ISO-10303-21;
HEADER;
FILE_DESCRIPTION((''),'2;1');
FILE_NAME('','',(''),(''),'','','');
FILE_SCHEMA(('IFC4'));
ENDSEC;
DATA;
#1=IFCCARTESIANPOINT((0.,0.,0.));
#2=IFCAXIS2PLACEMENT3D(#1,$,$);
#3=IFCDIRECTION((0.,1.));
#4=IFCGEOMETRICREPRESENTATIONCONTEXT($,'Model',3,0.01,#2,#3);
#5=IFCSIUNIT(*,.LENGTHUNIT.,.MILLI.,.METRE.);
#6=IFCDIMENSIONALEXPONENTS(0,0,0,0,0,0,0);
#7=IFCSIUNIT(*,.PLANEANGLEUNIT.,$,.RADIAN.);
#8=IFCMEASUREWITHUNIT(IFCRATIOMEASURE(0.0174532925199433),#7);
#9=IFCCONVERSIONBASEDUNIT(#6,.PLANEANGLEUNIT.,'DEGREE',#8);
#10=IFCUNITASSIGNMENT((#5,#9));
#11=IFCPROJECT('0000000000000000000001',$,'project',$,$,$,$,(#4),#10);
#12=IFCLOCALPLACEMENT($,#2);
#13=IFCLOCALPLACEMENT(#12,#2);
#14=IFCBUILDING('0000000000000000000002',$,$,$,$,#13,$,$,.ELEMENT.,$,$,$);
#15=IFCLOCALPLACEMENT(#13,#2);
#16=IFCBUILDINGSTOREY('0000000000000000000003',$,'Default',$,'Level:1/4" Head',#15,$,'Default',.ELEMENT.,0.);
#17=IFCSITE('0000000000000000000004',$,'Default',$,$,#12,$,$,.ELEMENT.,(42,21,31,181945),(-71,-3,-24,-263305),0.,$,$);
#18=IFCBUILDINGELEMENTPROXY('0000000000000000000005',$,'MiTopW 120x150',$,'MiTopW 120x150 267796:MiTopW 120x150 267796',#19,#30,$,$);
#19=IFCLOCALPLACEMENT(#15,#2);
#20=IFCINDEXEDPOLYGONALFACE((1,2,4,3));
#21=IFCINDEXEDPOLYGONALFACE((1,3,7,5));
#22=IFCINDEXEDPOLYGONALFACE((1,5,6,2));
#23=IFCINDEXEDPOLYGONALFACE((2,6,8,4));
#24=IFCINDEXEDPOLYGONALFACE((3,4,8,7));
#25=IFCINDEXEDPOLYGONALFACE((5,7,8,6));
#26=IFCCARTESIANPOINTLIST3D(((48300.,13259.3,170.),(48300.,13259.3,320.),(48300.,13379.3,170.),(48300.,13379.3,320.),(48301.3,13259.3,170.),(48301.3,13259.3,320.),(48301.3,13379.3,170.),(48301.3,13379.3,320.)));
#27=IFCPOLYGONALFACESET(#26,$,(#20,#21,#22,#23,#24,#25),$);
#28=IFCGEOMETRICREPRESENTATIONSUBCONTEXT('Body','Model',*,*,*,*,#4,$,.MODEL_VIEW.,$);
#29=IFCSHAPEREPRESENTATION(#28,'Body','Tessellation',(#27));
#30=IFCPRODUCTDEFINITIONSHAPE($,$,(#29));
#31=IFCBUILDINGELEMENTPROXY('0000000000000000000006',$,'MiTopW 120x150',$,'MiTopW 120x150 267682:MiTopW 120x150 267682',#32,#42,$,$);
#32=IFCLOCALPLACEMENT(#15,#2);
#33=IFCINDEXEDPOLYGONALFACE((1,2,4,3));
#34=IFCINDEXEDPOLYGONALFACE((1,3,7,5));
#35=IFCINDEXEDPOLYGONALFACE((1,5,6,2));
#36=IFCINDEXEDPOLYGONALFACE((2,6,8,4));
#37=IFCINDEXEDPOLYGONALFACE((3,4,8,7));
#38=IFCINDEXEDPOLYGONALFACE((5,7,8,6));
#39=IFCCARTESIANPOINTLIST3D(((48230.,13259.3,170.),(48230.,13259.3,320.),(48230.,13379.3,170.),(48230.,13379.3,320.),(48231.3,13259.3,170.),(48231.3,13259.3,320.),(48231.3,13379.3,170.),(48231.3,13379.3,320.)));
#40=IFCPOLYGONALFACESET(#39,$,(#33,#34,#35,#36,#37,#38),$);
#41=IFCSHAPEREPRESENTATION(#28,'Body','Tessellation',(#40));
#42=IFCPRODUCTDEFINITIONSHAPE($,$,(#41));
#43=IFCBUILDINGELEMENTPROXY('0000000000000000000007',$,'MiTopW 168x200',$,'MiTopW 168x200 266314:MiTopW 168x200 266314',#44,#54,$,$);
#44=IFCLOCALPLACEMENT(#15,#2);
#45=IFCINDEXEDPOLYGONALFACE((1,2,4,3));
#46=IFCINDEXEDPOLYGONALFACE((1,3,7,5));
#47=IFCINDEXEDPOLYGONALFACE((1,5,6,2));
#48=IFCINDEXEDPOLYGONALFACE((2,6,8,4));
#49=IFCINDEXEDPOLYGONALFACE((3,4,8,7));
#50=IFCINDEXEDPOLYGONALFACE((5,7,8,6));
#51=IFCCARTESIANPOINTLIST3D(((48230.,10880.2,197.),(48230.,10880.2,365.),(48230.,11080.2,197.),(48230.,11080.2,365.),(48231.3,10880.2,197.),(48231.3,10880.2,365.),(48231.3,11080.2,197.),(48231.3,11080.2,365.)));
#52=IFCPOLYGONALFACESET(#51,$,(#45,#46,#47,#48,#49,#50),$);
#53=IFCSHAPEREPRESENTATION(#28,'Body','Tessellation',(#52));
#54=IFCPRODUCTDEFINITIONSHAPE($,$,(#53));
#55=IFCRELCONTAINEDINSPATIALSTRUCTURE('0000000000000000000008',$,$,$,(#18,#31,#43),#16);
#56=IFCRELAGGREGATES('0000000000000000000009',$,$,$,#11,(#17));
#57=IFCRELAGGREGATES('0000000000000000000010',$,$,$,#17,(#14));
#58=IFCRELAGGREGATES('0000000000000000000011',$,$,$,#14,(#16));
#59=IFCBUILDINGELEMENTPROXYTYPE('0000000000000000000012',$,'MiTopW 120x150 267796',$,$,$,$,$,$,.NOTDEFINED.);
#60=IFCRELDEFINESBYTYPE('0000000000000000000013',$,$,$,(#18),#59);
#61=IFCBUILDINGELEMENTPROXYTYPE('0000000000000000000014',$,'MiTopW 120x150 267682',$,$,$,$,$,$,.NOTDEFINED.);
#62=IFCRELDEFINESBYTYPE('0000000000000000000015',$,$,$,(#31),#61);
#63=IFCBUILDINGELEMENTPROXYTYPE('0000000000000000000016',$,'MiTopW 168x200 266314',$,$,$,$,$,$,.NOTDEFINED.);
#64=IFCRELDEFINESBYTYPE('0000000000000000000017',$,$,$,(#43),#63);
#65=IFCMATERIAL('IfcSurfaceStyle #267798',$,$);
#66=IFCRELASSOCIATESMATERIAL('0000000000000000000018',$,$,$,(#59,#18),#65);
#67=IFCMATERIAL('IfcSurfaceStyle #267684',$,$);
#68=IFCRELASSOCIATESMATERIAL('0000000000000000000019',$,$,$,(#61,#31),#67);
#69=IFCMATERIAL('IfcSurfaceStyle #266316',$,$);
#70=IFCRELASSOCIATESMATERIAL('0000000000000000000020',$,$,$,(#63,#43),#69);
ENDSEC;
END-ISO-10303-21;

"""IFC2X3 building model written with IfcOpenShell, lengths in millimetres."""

from ifc_helpers import new_model, entity, si_unit, converted_unit, direction, frame, origin, origin_2d_with_axis, place, context, subcontext, project, spatial, rectangle, extrude, source, transform, mapped, material, type_object, type_shapes, element, save


model = new_model("IFC2X3")

# Units and contexts
model_context = context("Model", 3, precision=0.01, world=origin(), true_north=direction((0.0, 1.0)))
body_context = subcontext(model_context, "Body", "Model", "MODEL_VIEW")
ifc_project = project(units=[si_unit("LENGTHUNIT", "METRE", prefix="MILLI"), converted_unit("PLANEANGLEUNIT", "DEGREE", entity("IfcRatioMeasure", 0.0174532925199433), si_unit("PLANEANGLEUNIT", "RADIAN"), dimensions=[0, 0, 0, 0, 0, 0, 0])], contexts=[model_context])

# Site, building, storey
site_placement = place(None, origin())
site = spatial("IfcSite", under=ifc_project, at=site_placement, Name="Default", CompositionType="ELEMENT", RefLatitude=(42, 21, 31, 181945), RefLongitude=(-71, -3, -24, -263305), RefElevation=0.0)
building_placement = place(site_placement, origin())
building = spatial("IfcBuilding", under=site, at=building_placement, CompositionType="ELEMENT")
storey_placement = place(building_placement, origin())
storey = spatial("IfcBuildingStorey", under=building, at=storey_placement, Name="Default", ObjectType="Level:1/4\" Head", LongName="Default", CompositionType="ELEMENT", Elevation=0.0)

# Building element proxies
ifc_material_1 = material(Name="IfcSurfaceStyle #267798")
building_element_proxy_type_1 = type_object("IfcBuildingElementProxyType", Name="MiTopW 120x150 267796", PredefinedType="NOTDEFINED", material=ifc_material_1)
shared_shape_1 = source(origin(), body_context, "Body", "SweptSolid", [
    extrude(rectangle(XDim=150.0, YDim=120.0, at=origin_2d_with_axis()), frame((75.0, 60.0, 0.0), z_axis=(0.0, 0.0, 1.0), x_axis=(-1.0, 0.0, 0.0)), (0.0, 0.0, 1.0), 1.3),
])
type_shapes(building_element_proxy_type_1, [shared_shape_1])
proxy_1_placement = place(building_placement, frame((48301.3, 13259.3, 170.0), z_axis=(-1.0, 0.0, 0.0), x_axis=(0.0, 0.0, 1.0)))
element("IfcBuildingElementProxy", 1, at=proxy_1_placement, inside=storey, type_object=building_element_proxy_type_1, material=ifc_material_1, Name="MiTopW 120x150", ObjectType="MiTopW 120x150 267796:MiTopW 120x150 267796", context=body_context, shape_type="MappedRepresentation", body=[
    mapped(shared_shape_1, transform((0.0, 0.0, 0.0), scale=1.0)),
])
ifc_material_2 = material(Name="IfcSurfaceStyle #267684")
building_element_proxy_type_2 = type_object("IfcBuildingElementProxyType", Name="MiTopW 120x150 267682", PredefinedType="NOTDEFINED", material=ifc_material_2)
shared_shape_2 = source(origin(), body_context, "Body", "SweptSolid", [
    extrude(rectangle(XDim=150.0, YDim=120.0, at=origin_2d_with_axis()), frame((75.0, 60.0, 0.0), z_axis=(0.0, 0.0, 1.0), x_axis=(-1.0, 0.0, 0.0)), (0.0, 0.0, 1.0), 1.3),
])
type_shapes(building_element_proxy_type_2, [shared_shape_2])
proxy_2_placement = place(building_placement, frame((48231.3, 13259.3, 170.0), z_axis=(-1.0, 0.0, 0.0), x_axis=(0.0, 0.0, 1.0)))
element("IfcBuildingElementProxy", 2, at=proxy_2_placement, inside=storey, type_object=building_element_proxy_type_2, material=ifc_material_2, Name="MiTopW 120x150", ObjectType="MiTopW 120x150 267682:MiTopW 120x150 267682", context=body_context, shape_type="MappedRepresentation", body=[
    mapped(shared_shape_2, transform((0.0, 0.0, 0.0), scale=1.0)),
])
ifc_material_3 = material(Name="IfcSurfaceStyle #266316")
building_element_proxy_type_3 = type_object("IfcBuildingElementProxyType", Name="MiTopW 168x200 266314", PredefinedType="NOTDEFINED", material=ifc_material_3)
shared_shape_3 = source(origin(), body_context, "Body", "SweptSolid", [
    extrude(rectangle(XDim=200.0, YDim=168.0, at=origin_2d_with_axis()), frame((100.0, 84.0, 0.0), z_axis=(0.0, 0.0, 1.0), x_axis=(-1.0, 0.0, 0.0)), (0.0, 0.0, 1.0), 1.3),
])
type_shapes(building_element_proxy_type_3, [shared_shape_3])
proxy_3_placement = place(building_placement, frame((48231.3, 10880.2, 365.0), z_axis=(-1.0, 0.0, 0.0), x_axis=(0.0, 1.0, 0.0)))
element("IfcBuildingElementProxy", 3, at=proxy_3_placement, inside=storey, type_object=building_element_proxy_type_3, material=ifc_material_3, Name="MiTopW 168x200", ObjectType="MiTopW 168x200 266314:MiTopW 168x200 266314", context=body_context, shape_type="MappedRepresentation", body=[
    mapped(shared_shape_3, transform((0.0, 0.0, 0.0), scale=1.0)),
])

save(model, "model.ifc")
